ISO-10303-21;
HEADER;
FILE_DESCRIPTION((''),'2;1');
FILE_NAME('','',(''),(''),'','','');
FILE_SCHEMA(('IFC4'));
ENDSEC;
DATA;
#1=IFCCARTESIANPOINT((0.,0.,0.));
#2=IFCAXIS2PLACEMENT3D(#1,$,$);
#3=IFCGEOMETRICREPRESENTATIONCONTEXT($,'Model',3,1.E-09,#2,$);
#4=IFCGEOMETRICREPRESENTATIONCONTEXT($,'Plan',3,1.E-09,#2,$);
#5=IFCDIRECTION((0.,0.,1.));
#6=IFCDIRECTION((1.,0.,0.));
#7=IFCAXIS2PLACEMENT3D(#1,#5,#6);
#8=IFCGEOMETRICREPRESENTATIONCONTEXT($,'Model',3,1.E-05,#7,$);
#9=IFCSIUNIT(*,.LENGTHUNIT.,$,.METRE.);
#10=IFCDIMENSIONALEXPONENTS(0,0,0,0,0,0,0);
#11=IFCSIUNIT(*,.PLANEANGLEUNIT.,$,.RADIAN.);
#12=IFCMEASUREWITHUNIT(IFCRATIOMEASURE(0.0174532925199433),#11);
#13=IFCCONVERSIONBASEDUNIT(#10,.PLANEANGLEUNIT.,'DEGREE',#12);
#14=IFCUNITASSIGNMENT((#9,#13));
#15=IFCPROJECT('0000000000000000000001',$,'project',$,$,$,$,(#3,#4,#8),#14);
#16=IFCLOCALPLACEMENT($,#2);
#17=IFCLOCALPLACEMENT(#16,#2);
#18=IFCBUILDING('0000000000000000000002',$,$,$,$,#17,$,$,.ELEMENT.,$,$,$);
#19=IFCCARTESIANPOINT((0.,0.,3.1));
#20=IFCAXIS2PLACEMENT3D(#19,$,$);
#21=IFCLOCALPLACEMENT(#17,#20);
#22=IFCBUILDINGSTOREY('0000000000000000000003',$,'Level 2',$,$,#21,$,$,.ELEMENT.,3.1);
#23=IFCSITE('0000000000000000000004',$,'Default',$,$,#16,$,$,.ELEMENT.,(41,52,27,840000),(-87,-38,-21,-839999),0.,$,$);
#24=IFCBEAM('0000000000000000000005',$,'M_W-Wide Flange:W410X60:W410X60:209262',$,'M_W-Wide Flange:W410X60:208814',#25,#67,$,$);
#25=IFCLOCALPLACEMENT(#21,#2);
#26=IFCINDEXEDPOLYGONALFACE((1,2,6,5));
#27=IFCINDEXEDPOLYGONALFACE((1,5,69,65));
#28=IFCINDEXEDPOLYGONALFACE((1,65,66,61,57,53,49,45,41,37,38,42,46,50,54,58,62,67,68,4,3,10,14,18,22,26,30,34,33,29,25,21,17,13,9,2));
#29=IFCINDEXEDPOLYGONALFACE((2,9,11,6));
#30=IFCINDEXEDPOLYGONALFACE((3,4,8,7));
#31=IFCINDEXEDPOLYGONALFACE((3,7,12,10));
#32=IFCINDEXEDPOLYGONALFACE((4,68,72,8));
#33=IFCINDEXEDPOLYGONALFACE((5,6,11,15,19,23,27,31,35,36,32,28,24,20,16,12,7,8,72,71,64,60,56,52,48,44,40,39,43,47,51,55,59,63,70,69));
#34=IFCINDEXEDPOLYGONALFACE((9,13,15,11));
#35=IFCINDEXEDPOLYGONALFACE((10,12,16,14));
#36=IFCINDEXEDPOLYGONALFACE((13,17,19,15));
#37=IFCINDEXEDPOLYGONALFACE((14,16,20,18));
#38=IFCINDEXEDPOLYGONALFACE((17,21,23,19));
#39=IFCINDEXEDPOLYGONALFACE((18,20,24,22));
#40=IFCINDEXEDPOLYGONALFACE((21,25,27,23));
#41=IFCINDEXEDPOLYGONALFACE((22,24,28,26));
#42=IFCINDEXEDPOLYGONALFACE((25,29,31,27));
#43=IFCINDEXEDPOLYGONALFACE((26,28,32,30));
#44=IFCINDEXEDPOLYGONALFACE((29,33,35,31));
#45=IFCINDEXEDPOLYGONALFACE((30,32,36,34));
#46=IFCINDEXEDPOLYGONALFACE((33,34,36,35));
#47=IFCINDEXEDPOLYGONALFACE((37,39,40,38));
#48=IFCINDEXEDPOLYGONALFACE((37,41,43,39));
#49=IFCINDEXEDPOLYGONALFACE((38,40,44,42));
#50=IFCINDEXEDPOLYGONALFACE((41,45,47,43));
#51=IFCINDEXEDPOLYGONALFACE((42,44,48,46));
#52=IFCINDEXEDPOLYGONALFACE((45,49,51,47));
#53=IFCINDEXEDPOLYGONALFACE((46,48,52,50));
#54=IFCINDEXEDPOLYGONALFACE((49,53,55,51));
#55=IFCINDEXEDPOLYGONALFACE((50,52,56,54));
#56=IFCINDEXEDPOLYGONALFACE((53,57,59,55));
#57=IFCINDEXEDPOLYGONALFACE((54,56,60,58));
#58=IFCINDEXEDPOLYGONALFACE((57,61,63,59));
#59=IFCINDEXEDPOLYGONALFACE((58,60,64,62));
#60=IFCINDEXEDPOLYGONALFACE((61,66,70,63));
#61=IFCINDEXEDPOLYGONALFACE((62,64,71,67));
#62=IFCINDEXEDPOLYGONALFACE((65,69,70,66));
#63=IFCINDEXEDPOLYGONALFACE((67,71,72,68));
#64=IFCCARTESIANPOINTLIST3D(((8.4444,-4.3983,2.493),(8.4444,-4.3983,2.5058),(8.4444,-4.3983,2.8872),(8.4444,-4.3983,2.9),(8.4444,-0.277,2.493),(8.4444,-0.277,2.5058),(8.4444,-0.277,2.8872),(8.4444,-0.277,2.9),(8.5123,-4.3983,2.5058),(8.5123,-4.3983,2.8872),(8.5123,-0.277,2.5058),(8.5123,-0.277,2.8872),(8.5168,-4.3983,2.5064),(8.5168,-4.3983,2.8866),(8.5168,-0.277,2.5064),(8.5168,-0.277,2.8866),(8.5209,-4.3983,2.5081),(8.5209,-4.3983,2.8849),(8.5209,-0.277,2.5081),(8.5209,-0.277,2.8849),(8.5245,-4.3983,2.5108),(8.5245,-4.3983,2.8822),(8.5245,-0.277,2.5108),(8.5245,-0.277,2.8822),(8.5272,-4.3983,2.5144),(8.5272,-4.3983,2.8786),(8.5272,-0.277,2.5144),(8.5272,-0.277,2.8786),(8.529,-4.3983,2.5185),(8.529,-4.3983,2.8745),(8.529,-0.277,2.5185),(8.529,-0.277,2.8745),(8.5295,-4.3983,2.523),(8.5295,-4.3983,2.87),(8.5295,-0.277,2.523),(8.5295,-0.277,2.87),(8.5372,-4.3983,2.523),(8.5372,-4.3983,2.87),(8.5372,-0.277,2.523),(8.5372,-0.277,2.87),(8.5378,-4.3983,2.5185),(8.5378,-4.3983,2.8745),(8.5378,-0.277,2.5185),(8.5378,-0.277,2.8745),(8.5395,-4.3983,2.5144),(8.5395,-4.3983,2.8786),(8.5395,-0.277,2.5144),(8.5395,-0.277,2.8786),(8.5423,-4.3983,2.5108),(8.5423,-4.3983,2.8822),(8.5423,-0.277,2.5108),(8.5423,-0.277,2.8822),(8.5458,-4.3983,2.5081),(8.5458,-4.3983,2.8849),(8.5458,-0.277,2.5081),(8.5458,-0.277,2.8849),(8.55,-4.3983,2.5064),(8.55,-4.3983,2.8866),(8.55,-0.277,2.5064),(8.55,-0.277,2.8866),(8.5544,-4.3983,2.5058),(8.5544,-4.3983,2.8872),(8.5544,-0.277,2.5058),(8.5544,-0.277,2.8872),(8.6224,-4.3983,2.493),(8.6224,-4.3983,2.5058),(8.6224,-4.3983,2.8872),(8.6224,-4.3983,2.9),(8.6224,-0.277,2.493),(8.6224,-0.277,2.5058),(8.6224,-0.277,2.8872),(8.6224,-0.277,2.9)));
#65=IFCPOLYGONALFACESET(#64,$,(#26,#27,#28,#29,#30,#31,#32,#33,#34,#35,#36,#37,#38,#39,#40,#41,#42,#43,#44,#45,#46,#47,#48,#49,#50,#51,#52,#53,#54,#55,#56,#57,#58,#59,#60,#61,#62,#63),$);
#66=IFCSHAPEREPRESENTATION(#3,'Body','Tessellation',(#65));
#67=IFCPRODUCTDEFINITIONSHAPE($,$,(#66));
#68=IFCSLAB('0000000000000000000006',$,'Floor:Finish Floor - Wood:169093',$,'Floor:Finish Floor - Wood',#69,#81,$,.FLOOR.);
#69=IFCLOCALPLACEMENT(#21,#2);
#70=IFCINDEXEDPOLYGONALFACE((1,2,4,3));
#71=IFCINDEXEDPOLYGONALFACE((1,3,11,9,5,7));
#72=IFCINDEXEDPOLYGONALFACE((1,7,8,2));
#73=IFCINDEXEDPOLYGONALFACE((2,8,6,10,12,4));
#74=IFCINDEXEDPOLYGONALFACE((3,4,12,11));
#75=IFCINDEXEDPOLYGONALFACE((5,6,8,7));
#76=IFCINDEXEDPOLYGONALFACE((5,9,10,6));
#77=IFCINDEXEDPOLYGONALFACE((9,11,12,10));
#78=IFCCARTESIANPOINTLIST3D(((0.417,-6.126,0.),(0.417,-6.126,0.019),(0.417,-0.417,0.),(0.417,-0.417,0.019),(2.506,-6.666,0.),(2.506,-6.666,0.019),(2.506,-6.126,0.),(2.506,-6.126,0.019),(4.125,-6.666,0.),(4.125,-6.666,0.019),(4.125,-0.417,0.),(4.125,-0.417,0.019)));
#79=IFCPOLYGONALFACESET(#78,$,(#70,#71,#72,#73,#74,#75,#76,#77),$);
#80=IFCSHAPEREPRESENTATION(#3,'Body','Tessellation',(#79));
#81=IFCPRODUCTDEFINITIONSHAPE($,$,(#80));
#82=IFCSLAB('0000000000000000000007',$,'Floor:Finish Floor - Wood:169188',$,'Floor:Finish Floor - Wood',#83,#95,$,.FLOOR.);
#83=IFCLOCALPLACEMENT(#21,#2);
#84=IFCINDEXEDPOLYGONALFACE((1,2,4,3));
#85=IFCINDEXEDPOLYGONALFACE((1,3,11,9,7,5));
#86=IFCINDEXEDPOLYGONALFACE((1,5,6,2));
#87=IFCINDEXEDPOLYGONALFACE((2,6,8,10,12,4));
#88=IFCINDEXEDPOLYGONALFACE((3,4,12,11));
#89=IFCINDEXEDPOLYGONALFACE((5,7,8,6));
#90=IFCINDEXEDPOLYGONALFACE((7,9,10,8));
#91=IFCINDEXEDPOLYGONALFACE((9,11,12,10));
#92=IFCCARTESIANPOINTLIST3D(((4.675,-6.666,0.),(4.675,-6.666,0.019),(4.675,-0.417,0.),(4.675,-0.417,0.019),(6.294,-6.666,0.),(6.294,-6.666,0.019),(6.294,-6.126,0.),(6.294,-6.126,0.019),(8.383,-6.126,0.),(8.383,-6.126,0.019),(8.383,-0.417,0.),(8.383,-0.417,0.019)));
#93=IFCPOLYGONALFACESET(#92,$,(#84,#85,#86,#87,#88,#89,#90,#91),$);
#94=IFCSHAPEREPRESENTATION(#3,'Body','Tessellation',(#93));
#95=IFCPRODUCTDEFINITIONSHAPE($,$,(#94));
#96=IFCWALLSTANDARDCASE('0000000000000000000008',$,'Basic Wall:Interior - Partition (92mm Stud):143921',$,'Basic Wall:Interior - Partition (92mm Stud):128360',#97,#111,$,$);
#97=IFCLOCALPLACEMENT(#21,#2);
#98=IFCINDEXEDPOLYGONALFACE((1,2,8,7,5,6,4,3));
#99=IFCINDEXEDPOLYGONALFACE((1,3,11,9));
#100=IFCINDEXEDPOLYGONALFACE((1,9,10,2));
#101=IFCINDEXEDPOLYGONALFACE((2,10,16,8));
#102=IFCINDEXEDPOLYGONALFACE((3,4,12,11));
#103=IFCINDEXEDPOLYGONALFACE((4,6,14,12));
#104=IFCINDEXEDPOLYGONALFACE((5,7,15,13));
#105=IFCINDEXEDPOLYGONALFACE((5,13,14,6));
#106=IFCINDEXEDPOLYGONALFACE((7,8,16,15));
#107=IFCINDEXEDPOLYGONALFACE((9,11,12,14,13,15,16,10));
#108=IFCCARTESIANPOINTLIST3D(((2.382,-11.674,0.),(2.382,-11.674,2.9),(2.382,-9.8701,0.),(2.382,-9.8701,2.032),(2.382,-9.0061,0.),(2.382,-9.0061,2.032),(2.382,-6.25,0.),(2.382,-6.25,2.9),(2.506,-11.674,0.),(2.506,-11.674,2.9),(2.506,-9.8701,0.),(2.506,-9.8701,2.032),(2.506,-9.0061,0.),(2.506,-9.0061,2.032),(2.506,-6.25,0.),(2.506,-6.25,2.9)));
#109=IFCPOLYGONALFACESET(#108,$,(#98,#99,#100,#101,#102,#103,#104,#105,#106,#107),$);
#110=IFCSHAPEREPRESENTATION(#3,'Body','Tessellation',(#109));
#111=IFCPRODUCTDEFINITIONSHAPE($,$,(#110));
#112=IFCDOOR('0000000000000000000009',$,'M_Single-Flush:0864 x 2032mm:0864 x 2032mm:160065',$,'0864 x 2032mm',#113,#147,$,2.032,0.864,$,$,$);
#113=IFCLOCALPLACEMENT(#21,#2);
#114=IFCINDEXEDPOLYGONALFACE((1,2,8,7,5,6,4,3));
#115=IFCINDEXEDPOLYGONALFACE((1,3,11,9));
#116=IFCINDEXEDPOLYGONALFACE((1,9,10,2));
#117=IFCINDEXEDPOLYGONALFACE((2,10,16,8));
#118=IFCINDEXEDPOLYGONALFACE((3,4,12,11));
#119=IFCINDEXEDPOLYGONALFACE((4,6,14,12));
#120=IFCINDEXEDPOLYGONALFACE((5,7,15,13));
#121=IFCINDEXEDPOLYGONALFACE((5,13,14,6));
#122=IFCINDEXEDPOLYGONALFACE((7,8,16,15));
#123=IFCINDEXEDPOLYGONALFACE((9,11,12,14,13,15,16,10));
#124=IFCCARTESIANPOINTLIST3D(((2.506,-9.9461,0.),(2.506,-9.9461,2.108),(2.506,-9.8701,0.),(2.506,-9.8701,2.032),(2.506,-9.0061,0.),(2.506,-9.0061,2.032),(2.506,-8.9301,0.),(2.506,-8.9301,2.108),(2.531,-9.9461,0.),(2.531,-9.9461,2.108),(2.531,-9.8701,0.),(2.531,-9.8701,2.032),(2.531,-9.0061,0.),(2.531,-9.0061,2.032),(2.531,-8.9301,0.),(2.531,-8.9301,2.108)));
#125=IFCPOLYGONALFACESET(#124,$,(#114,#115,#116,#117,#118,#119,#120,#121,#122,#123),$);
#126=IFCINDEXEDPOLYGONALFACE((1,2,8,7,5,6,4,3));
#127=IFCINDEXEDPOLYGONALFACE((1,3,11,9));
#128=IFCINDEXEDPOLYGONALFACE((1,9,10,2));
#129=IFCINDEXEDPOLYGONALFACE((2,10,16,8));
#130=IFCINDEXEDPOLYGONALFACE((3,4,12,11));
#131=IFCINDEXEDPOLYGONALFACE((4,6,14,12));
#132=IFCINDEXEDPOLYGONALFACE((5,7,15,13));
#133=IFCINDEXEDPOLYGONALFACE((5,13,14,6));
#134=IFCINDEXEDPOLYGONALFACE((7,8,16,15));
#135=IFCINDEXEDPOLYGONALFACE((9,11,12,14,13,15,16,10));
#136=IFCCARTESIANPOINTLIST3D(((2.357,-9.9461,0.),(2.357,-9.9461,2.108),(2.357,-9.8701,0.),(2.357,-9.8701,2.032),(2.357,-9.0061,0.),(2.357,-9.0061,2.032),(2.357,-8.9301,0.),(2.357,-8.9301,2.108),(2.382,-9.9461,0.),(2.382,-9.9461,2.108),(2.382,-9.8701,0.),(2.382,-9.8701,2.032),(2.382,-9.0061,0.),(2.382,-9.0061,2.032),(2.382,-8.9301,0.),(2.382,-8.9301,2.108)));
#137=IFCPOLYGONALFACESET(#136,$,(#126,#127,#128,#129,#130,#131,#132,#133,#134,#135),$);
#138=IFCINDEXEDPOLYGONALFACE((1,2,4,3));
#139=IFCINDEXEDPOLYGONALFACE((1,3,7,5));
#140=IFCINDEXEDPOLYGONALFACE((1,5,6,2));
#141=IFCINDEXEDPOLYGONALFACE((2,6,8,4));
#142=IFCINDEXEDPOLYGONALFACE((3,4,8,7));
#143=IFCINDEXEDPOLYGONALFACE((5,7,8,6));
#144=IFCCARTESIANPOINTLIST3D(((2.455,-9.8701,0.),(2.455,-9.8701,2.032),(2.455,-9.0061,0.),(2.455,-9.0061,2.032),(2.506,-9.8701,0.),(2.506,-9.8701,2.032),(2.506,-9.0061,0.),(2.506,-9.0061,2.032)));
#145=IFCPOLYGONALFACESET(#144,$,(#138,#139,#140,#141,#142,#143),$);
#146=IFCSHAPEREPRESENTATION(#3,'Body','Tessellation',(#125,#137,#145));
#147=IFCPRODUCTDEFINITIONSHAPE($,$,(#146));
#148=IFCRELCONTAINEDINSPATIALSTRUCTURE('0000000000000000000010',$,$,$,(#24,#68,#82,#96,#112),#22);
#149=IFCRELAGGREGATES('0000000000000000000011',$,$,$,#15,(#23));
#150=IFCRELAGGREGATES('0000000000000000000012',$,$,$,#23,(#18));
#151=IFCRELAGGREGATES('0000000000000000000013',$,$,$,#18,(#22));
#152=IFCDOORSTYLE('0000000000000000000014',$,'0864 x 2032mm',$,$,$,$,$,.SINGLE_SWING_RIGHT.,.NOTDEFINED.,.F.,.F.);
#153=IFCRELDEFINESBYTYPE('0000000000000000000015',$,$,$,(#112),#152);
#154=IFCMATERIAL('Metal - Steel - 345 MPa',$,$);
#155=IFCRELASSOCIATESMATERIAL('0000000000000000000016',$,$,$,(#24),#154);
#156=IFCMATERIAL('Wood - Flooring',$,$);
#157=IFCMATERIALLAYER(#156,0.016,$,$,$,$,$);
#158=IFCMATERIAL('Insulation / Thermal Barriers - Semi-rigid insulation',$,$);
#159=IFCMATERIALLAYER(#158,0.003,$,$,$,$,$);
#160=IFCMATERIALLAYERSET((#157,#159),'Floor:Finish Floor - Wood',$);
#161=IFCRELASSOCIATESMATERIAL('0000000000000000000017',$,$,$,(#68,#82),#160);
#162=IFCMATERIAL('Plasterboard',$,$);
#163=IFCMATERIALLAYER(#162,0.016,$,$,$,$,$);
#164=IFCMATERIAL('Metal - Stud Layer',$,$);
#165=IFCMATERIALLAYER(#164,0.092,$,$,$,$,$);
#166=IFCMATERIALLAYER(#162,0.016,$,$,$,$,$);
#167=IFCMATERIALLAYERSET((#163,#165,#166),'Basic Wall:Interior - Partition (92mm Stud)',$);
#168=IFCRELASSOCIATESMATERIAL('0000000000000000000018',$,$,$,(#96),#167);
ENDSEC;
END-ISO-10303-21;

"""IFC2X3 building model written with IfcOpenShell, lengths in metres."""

from ifc_helpers import new_model, entity, si_unit, converted_unit, frame, frame_2d, origin, origin_with_axes, origin_2d_with_axis, place, context, project, spatial, polyline, circle_curve, parameter, trimmed, segment, composite_curve, rectangle, outline, extrude, source, transform, mapped, material, layer, layer_set, layer_usage, type_object, type_shapes, element, fill, save


model = new_model("IFC2X3")

# Units and contexts
model_context_1 = context("Model", 3, precision=1e-09, world=origin())
plan_context = context("Plan", 3, precision=1e-09, world=origin())
model_context_2 = context("Model", 3, precision=1e-05, world=origin_with_axes())
ifc_project = project(units=[si_unit("LENGTHUNIT", "METRE"), converted_unit("PLANEANGLEUNIT", "DEGREE", entity("IfcRatioMeasure", 0.0174532925199433), si_unit("PLANEANGLEUNIT", "RADIAN"), dimensions=[0, 0, 0, 0, 0, 0, 0])], contexts=[model_context_1, plan_context, model_context_2])

# Site, building, storey
site_placement = place(None, origin())
site = spatial("IfcSite", under=ifc_project, at=site_placement, Name="Default", CompositionType="ELEMENT", RefLatitude=(41, 52, 27, 840000), RefLongitude=(-87, -38, -21, -839999), RefElevation=0.0)
building_placement = place(site_placement, origin())
building = spatial("IfcBuilding", under=site, at=building_placement, CompositionType="ELEMENT")
storey_placement = place(building_placement, frame((0.0, 0.0, 3.1)))
storey = spatial("IfcBuildingStorey", under=building, at=storey_placement, Name="Level 2", CompositionType="ELEMENT", Elevation=3.1)

# Beam
ifc_material_1 = material(Name="Metal - Steel - 345 MPa")
beam_1_placement = place(storey_placement, frame((8.5334, -4.3983, 2.9)))
element("IfcBeam", 1, at=beam_1_placement, inside=storey, material=ifc_material_1, Name="M_W-Wide Flange:W410X60:W410X60:209262", ObjectType="M_W-Wide Flange:W410X60:208814", context=model_context_1, shape_type="SweptSolid", body=[
    extrude(outline(composite_curve([segment(polyline([(-0.089, -0.1907), (-0.089, -0.2035)]), True, "CONTINUOUS"), segment(polyline([(-0.089, -0.2035), (0.089, -0.2035)]), True, "CONTINUOUS"), segment(polyline([(0.089, -0.2035), (0.089, -0.1907)]), True, "CONTINUOUS"), segment(polyline([(0.089, -0.1907), (0.021, -0.1907)]), True, "CONTINUOUS"), segment(trimmed(circle_curve(frame_2d((0.021, -0.1735), x_axis=(0.0, -1.0)), 0.0172), [parameter(270.0)], [parameter(360.0)], True, "PARAMETER"), False, "CONTINUOUS"), segment(polyline([(0.0038, -0.1735), (0.0038, 0.1735)]), True, "CONTINUOUS"), segment(trimmed(circle_curve(frame_2d((0.021, 0.1735), x_axis=(-1.0, 0.0)), 0.0172), [parameter(270.0)], [parameter(360.0)], True, "PARAMETER"), False, "CONTINUOUS"), segment(polyline([(0.021, 0.1907), (0.089, 0.1907)]), True, "CONTINUOUS"), segment(polyline([(0.089, 0.1907), (0.089, 0.2035)]), True, "CONTINUOUS"), segment(polyline([(0.089, 0.2035), (-0.089, 0.2035)]), True, "CONTINUOUS"), segment(polyline([(-0.089, 0.2035), (-0.089, 0.1907)]), True, "CONTINUOUS"), segment(polyline([(-0.089, 0.1907), (-0.0211, 0.1907)]), True, "CONTINUOUS"), segment(trimmed(circle_curve(frame_2d((-0.0211, 0.1735), x_axis=(0.0, 1.0)), 0.0172), [parameter(270.0)], [parameter(0.0)], True, "PARAMETER"), False, "CONTINUOUS"), segment(polyline([(-0.0039, 0.1735), (-0.0039, -0.1735)]), True, "CONTINUOUS"), segment(trimmed(circle_curve(frame_2d((-0.0211, -0.1735), x_axis=(1.0, 0.0)), 0.0172), [parameter(270.0)], [parameter(0.0)], True, "PARAMETER"), False, "CONTINUOUS"), segment(polyline([(-0.0211, -0.1907), (-0.089, -0.1907)]), True, "CONTINUOUS")], self_intersect=False)), frame((0.0, 0.0, -0.2035), z_axis=(0.0, -1.0, 0.0), x_axis=(1.0, 0.0, 0.0)), (0.0, 0.0, -1.0), 4.1213),
])

# Slabs
ifc_material_2 = material(Name="Wood - Flooring")
ifc_layer_1 = layer(ifc_material_2, 0.016)
ifc_material_3 = material(Name="Insulation / Thermal Barriers - Semi-rigid insulation")
ifc_layer_2 = layer(ifc_material_3, 0.003)
ifc_layer_set_1 = layer_set([ifc_layer_1, ifc_layer_2], Name="Floor:Finish Floor - Wood")
ifc_layer_usage_1 = layer_usage(ifc_layer_set_1, "AXIS3", "POSITIVE", 0.0)
slab_1_placement = place(storey_placement, frame((0.417, -6.666, 0.0)))
element("IfcSlab", 2, at=slab_1_placement, inside=storey, material=ifc_layer_usage_1, Name="Floor:Finish Floor - Wood:169093", ObjectType="Floor:Finish Floor - Wood", PredefinedType="FLOOR", context=model_context_1, shape_type="SweptSolid", body=[
    extrude(outline(polyline([(1.854, 3.1245), (-1.854, 3.1245), (-1.854, -3.1245), (-0.235, -3.1245), (-0.235, -2.5845), (1.854, -2.5845), (1.854, 3.1245)])), frame((1.854, 3.1245, 0.019), z_axis=(0.0, 0.0, -1.0), x_axis=(-1.0, 0.0, 0.0)), (0.0, 0.0, 1.0), 0.019),
])
ifc_layer_usage_2 = layer_usage(ifc_layer_set_1, "AXIS3", "POSITIVE", 0.0)
slab_2_placement = place(storey_placement, frame((4.675, -6.666, 0.0)))
element("IfcSlab", 3, at=slab_2_placement, inside=storey, material=ifc_layer_usage_2, Name="Floor:Finish Floor - Wood:169188", ObjectType="Floor:Finish Floor - Wood", PredefinedType="FLOOR", context=model_context_1, shape_type="SweptSolid", body=[
    extrude(outline(polyline([(-1.854, 3.1245), (-1.854, -2.5845), (0.235, -2.5845), (0.235, -3.1245), (1.854, -3.1245), (1.854, 3.1245), (-1.854, 3.1245)])), frame((1.854, 3.1245, 0.019), z_axis=(0.0, 0.0, -1.0), x_axis=(-1.0, 0.0, 0.0)), (0.0, 0.0, 1.0), 0.019),
])

# Shared definitions
ifc_material_4 = material(Name="Metal - Stud Layer")
ifc_material_5 = material(Name="Plasterboard")

# Wall, opening, door
ifc_layer_3 = layer(ifc_material_5, 0.016)
ifc_layer_4 = layer(ifc_material_4, 0.092)
ifc_layer_5 = layer(ifc_material_5, 0.016)
ifc_layer_set_2 = layer_set([ifc_layer_3, ifc_layer_4, ifc_layer_5], Name="Basic Wall:Interior - Partition (92mm Stud)")
ifc_layer_usage_3 = layer_usage(ifc_layer_set_2, "AXIS2", "NEGATIVE", 0.062)
wall_1_placement = place(storey_placement, frame((2.444, -6.25, 0.0), z_axis=(0.0, 0.0, 1.0), x_axis=(0.0, -1.0, 0.0)))
wall_1 = element("IfcWallStandardCase", 4, at=wall_1_placement, inside=storey, material=ifc_layer_usage_3, Name="Basic Wall:Interior - Partition (92mm Stud):143921", ObjectType="Basic Wall:Interior - Partition (92mm Stud):128360", context=model_context_1, shape_type="SweptSolid", body=[
    extrude(rectangle(XDim=5.424, YDim=0.124, at=frame_2d((2.712, 0.0), x_axis=(-1.0, 0.0))), origin(), (0.0, 0.0, 1.0), 2.9),
])
opening_1_placement = place(wall_1_placement, frame((2.7561, -0.062, 0.0)))
opening_1 = element("IfcOpeningElement", 5, at=opening_1_placement, cuts=wall_1, ObjectType="Opening", context=model_context_1, shape_type="SweptSolid", body=[
    extrude(rectangle(XDim=0.864, YDim=2.032, at=frame_2d((1.016, 0.432), x_axis=(0.0, 1.0))), frame((0.0, 0.0, 0.0), z_axis=(0.0, 1.0, 0.0), x_axis=(0.0, 0.0, 1.0)), (0.0, 0.0, 1.0), 0.124),
])
door_style_1 = type_object("IfcDoorStyle", Name="0864 x 2032mm", ConstructionType="NOTDEFINED", OperationType="SINGLE_SWING_RIGHT", ParameterTakesPrecedence=False, Sizeable=False)
shared_shape_1 = source(origin(), model_context_1, "Body", "SweptSolid", [
    extrude(outline(polyline([(-0.508, -1.073), (0.508, -1.073), (0.508, 1.035), (0.432, 1.035), (0.432, -0.997), (-0.432, -0.997), (-0.432, 1.035), (-0.508, 1.035), (-0.508, -1.073)])), frame((0.432, 0.124, 1.035), z_axis=(0.0, 1.0, 0.0), x_axis=(1.0, 0.0, 0.0)), (0.0, 0.0, 1.0), 0.025),
    extrude(outline(polyline([(-1.073, -0.508), (1.035, -0.508), (1.035, -0.432), (-0.997, -0.432), (-0.997, 0.432), (1.035, 0.432), (1.035, 0.508), (-1.073, 0.508), (-1.073, -0.508)])), frame((0.432, -0.025, 1.035), z_axis=(0.0, 1.0, 0.0), x_axis=(0.0, 0.0, -1.0)), (0.0, 0.0, 1.0), 0.025),
    extrude(rectangle(XDim=0.051, YDim=0.864, at=origin_2d_with_axis()), frame((0.432, 0.0985, 0.0), z_axis=(0.0, 0.0, 1.0), x_axis=(0.0, 1.0, 0.0)), (0.0, 0.0, 1.0), 2.032),
])
type_shapes(door_style_1, [shared_shape_1])
door_1_placement = place(opening_1_placement, origin())
door_1 = element("IfcDoor", 6, at=door_1_placement, inside=storey, type_object=door_style_1, Name="M_Single-Flush:0864 x 2032mm:0864 x 2032mm:160065", ObjectType="0864 x 2032mm", OverallHeight=2.032, OverallWidth=0.864, context=model_context_1, shape_type="MappedRepresentation", body=[
    mapped(shared_shape_1, transform((0.0, 0.0, 0.0), scale=1.0)),
])
fill(opening_1, door_1)

save(model, "model.ifc")
